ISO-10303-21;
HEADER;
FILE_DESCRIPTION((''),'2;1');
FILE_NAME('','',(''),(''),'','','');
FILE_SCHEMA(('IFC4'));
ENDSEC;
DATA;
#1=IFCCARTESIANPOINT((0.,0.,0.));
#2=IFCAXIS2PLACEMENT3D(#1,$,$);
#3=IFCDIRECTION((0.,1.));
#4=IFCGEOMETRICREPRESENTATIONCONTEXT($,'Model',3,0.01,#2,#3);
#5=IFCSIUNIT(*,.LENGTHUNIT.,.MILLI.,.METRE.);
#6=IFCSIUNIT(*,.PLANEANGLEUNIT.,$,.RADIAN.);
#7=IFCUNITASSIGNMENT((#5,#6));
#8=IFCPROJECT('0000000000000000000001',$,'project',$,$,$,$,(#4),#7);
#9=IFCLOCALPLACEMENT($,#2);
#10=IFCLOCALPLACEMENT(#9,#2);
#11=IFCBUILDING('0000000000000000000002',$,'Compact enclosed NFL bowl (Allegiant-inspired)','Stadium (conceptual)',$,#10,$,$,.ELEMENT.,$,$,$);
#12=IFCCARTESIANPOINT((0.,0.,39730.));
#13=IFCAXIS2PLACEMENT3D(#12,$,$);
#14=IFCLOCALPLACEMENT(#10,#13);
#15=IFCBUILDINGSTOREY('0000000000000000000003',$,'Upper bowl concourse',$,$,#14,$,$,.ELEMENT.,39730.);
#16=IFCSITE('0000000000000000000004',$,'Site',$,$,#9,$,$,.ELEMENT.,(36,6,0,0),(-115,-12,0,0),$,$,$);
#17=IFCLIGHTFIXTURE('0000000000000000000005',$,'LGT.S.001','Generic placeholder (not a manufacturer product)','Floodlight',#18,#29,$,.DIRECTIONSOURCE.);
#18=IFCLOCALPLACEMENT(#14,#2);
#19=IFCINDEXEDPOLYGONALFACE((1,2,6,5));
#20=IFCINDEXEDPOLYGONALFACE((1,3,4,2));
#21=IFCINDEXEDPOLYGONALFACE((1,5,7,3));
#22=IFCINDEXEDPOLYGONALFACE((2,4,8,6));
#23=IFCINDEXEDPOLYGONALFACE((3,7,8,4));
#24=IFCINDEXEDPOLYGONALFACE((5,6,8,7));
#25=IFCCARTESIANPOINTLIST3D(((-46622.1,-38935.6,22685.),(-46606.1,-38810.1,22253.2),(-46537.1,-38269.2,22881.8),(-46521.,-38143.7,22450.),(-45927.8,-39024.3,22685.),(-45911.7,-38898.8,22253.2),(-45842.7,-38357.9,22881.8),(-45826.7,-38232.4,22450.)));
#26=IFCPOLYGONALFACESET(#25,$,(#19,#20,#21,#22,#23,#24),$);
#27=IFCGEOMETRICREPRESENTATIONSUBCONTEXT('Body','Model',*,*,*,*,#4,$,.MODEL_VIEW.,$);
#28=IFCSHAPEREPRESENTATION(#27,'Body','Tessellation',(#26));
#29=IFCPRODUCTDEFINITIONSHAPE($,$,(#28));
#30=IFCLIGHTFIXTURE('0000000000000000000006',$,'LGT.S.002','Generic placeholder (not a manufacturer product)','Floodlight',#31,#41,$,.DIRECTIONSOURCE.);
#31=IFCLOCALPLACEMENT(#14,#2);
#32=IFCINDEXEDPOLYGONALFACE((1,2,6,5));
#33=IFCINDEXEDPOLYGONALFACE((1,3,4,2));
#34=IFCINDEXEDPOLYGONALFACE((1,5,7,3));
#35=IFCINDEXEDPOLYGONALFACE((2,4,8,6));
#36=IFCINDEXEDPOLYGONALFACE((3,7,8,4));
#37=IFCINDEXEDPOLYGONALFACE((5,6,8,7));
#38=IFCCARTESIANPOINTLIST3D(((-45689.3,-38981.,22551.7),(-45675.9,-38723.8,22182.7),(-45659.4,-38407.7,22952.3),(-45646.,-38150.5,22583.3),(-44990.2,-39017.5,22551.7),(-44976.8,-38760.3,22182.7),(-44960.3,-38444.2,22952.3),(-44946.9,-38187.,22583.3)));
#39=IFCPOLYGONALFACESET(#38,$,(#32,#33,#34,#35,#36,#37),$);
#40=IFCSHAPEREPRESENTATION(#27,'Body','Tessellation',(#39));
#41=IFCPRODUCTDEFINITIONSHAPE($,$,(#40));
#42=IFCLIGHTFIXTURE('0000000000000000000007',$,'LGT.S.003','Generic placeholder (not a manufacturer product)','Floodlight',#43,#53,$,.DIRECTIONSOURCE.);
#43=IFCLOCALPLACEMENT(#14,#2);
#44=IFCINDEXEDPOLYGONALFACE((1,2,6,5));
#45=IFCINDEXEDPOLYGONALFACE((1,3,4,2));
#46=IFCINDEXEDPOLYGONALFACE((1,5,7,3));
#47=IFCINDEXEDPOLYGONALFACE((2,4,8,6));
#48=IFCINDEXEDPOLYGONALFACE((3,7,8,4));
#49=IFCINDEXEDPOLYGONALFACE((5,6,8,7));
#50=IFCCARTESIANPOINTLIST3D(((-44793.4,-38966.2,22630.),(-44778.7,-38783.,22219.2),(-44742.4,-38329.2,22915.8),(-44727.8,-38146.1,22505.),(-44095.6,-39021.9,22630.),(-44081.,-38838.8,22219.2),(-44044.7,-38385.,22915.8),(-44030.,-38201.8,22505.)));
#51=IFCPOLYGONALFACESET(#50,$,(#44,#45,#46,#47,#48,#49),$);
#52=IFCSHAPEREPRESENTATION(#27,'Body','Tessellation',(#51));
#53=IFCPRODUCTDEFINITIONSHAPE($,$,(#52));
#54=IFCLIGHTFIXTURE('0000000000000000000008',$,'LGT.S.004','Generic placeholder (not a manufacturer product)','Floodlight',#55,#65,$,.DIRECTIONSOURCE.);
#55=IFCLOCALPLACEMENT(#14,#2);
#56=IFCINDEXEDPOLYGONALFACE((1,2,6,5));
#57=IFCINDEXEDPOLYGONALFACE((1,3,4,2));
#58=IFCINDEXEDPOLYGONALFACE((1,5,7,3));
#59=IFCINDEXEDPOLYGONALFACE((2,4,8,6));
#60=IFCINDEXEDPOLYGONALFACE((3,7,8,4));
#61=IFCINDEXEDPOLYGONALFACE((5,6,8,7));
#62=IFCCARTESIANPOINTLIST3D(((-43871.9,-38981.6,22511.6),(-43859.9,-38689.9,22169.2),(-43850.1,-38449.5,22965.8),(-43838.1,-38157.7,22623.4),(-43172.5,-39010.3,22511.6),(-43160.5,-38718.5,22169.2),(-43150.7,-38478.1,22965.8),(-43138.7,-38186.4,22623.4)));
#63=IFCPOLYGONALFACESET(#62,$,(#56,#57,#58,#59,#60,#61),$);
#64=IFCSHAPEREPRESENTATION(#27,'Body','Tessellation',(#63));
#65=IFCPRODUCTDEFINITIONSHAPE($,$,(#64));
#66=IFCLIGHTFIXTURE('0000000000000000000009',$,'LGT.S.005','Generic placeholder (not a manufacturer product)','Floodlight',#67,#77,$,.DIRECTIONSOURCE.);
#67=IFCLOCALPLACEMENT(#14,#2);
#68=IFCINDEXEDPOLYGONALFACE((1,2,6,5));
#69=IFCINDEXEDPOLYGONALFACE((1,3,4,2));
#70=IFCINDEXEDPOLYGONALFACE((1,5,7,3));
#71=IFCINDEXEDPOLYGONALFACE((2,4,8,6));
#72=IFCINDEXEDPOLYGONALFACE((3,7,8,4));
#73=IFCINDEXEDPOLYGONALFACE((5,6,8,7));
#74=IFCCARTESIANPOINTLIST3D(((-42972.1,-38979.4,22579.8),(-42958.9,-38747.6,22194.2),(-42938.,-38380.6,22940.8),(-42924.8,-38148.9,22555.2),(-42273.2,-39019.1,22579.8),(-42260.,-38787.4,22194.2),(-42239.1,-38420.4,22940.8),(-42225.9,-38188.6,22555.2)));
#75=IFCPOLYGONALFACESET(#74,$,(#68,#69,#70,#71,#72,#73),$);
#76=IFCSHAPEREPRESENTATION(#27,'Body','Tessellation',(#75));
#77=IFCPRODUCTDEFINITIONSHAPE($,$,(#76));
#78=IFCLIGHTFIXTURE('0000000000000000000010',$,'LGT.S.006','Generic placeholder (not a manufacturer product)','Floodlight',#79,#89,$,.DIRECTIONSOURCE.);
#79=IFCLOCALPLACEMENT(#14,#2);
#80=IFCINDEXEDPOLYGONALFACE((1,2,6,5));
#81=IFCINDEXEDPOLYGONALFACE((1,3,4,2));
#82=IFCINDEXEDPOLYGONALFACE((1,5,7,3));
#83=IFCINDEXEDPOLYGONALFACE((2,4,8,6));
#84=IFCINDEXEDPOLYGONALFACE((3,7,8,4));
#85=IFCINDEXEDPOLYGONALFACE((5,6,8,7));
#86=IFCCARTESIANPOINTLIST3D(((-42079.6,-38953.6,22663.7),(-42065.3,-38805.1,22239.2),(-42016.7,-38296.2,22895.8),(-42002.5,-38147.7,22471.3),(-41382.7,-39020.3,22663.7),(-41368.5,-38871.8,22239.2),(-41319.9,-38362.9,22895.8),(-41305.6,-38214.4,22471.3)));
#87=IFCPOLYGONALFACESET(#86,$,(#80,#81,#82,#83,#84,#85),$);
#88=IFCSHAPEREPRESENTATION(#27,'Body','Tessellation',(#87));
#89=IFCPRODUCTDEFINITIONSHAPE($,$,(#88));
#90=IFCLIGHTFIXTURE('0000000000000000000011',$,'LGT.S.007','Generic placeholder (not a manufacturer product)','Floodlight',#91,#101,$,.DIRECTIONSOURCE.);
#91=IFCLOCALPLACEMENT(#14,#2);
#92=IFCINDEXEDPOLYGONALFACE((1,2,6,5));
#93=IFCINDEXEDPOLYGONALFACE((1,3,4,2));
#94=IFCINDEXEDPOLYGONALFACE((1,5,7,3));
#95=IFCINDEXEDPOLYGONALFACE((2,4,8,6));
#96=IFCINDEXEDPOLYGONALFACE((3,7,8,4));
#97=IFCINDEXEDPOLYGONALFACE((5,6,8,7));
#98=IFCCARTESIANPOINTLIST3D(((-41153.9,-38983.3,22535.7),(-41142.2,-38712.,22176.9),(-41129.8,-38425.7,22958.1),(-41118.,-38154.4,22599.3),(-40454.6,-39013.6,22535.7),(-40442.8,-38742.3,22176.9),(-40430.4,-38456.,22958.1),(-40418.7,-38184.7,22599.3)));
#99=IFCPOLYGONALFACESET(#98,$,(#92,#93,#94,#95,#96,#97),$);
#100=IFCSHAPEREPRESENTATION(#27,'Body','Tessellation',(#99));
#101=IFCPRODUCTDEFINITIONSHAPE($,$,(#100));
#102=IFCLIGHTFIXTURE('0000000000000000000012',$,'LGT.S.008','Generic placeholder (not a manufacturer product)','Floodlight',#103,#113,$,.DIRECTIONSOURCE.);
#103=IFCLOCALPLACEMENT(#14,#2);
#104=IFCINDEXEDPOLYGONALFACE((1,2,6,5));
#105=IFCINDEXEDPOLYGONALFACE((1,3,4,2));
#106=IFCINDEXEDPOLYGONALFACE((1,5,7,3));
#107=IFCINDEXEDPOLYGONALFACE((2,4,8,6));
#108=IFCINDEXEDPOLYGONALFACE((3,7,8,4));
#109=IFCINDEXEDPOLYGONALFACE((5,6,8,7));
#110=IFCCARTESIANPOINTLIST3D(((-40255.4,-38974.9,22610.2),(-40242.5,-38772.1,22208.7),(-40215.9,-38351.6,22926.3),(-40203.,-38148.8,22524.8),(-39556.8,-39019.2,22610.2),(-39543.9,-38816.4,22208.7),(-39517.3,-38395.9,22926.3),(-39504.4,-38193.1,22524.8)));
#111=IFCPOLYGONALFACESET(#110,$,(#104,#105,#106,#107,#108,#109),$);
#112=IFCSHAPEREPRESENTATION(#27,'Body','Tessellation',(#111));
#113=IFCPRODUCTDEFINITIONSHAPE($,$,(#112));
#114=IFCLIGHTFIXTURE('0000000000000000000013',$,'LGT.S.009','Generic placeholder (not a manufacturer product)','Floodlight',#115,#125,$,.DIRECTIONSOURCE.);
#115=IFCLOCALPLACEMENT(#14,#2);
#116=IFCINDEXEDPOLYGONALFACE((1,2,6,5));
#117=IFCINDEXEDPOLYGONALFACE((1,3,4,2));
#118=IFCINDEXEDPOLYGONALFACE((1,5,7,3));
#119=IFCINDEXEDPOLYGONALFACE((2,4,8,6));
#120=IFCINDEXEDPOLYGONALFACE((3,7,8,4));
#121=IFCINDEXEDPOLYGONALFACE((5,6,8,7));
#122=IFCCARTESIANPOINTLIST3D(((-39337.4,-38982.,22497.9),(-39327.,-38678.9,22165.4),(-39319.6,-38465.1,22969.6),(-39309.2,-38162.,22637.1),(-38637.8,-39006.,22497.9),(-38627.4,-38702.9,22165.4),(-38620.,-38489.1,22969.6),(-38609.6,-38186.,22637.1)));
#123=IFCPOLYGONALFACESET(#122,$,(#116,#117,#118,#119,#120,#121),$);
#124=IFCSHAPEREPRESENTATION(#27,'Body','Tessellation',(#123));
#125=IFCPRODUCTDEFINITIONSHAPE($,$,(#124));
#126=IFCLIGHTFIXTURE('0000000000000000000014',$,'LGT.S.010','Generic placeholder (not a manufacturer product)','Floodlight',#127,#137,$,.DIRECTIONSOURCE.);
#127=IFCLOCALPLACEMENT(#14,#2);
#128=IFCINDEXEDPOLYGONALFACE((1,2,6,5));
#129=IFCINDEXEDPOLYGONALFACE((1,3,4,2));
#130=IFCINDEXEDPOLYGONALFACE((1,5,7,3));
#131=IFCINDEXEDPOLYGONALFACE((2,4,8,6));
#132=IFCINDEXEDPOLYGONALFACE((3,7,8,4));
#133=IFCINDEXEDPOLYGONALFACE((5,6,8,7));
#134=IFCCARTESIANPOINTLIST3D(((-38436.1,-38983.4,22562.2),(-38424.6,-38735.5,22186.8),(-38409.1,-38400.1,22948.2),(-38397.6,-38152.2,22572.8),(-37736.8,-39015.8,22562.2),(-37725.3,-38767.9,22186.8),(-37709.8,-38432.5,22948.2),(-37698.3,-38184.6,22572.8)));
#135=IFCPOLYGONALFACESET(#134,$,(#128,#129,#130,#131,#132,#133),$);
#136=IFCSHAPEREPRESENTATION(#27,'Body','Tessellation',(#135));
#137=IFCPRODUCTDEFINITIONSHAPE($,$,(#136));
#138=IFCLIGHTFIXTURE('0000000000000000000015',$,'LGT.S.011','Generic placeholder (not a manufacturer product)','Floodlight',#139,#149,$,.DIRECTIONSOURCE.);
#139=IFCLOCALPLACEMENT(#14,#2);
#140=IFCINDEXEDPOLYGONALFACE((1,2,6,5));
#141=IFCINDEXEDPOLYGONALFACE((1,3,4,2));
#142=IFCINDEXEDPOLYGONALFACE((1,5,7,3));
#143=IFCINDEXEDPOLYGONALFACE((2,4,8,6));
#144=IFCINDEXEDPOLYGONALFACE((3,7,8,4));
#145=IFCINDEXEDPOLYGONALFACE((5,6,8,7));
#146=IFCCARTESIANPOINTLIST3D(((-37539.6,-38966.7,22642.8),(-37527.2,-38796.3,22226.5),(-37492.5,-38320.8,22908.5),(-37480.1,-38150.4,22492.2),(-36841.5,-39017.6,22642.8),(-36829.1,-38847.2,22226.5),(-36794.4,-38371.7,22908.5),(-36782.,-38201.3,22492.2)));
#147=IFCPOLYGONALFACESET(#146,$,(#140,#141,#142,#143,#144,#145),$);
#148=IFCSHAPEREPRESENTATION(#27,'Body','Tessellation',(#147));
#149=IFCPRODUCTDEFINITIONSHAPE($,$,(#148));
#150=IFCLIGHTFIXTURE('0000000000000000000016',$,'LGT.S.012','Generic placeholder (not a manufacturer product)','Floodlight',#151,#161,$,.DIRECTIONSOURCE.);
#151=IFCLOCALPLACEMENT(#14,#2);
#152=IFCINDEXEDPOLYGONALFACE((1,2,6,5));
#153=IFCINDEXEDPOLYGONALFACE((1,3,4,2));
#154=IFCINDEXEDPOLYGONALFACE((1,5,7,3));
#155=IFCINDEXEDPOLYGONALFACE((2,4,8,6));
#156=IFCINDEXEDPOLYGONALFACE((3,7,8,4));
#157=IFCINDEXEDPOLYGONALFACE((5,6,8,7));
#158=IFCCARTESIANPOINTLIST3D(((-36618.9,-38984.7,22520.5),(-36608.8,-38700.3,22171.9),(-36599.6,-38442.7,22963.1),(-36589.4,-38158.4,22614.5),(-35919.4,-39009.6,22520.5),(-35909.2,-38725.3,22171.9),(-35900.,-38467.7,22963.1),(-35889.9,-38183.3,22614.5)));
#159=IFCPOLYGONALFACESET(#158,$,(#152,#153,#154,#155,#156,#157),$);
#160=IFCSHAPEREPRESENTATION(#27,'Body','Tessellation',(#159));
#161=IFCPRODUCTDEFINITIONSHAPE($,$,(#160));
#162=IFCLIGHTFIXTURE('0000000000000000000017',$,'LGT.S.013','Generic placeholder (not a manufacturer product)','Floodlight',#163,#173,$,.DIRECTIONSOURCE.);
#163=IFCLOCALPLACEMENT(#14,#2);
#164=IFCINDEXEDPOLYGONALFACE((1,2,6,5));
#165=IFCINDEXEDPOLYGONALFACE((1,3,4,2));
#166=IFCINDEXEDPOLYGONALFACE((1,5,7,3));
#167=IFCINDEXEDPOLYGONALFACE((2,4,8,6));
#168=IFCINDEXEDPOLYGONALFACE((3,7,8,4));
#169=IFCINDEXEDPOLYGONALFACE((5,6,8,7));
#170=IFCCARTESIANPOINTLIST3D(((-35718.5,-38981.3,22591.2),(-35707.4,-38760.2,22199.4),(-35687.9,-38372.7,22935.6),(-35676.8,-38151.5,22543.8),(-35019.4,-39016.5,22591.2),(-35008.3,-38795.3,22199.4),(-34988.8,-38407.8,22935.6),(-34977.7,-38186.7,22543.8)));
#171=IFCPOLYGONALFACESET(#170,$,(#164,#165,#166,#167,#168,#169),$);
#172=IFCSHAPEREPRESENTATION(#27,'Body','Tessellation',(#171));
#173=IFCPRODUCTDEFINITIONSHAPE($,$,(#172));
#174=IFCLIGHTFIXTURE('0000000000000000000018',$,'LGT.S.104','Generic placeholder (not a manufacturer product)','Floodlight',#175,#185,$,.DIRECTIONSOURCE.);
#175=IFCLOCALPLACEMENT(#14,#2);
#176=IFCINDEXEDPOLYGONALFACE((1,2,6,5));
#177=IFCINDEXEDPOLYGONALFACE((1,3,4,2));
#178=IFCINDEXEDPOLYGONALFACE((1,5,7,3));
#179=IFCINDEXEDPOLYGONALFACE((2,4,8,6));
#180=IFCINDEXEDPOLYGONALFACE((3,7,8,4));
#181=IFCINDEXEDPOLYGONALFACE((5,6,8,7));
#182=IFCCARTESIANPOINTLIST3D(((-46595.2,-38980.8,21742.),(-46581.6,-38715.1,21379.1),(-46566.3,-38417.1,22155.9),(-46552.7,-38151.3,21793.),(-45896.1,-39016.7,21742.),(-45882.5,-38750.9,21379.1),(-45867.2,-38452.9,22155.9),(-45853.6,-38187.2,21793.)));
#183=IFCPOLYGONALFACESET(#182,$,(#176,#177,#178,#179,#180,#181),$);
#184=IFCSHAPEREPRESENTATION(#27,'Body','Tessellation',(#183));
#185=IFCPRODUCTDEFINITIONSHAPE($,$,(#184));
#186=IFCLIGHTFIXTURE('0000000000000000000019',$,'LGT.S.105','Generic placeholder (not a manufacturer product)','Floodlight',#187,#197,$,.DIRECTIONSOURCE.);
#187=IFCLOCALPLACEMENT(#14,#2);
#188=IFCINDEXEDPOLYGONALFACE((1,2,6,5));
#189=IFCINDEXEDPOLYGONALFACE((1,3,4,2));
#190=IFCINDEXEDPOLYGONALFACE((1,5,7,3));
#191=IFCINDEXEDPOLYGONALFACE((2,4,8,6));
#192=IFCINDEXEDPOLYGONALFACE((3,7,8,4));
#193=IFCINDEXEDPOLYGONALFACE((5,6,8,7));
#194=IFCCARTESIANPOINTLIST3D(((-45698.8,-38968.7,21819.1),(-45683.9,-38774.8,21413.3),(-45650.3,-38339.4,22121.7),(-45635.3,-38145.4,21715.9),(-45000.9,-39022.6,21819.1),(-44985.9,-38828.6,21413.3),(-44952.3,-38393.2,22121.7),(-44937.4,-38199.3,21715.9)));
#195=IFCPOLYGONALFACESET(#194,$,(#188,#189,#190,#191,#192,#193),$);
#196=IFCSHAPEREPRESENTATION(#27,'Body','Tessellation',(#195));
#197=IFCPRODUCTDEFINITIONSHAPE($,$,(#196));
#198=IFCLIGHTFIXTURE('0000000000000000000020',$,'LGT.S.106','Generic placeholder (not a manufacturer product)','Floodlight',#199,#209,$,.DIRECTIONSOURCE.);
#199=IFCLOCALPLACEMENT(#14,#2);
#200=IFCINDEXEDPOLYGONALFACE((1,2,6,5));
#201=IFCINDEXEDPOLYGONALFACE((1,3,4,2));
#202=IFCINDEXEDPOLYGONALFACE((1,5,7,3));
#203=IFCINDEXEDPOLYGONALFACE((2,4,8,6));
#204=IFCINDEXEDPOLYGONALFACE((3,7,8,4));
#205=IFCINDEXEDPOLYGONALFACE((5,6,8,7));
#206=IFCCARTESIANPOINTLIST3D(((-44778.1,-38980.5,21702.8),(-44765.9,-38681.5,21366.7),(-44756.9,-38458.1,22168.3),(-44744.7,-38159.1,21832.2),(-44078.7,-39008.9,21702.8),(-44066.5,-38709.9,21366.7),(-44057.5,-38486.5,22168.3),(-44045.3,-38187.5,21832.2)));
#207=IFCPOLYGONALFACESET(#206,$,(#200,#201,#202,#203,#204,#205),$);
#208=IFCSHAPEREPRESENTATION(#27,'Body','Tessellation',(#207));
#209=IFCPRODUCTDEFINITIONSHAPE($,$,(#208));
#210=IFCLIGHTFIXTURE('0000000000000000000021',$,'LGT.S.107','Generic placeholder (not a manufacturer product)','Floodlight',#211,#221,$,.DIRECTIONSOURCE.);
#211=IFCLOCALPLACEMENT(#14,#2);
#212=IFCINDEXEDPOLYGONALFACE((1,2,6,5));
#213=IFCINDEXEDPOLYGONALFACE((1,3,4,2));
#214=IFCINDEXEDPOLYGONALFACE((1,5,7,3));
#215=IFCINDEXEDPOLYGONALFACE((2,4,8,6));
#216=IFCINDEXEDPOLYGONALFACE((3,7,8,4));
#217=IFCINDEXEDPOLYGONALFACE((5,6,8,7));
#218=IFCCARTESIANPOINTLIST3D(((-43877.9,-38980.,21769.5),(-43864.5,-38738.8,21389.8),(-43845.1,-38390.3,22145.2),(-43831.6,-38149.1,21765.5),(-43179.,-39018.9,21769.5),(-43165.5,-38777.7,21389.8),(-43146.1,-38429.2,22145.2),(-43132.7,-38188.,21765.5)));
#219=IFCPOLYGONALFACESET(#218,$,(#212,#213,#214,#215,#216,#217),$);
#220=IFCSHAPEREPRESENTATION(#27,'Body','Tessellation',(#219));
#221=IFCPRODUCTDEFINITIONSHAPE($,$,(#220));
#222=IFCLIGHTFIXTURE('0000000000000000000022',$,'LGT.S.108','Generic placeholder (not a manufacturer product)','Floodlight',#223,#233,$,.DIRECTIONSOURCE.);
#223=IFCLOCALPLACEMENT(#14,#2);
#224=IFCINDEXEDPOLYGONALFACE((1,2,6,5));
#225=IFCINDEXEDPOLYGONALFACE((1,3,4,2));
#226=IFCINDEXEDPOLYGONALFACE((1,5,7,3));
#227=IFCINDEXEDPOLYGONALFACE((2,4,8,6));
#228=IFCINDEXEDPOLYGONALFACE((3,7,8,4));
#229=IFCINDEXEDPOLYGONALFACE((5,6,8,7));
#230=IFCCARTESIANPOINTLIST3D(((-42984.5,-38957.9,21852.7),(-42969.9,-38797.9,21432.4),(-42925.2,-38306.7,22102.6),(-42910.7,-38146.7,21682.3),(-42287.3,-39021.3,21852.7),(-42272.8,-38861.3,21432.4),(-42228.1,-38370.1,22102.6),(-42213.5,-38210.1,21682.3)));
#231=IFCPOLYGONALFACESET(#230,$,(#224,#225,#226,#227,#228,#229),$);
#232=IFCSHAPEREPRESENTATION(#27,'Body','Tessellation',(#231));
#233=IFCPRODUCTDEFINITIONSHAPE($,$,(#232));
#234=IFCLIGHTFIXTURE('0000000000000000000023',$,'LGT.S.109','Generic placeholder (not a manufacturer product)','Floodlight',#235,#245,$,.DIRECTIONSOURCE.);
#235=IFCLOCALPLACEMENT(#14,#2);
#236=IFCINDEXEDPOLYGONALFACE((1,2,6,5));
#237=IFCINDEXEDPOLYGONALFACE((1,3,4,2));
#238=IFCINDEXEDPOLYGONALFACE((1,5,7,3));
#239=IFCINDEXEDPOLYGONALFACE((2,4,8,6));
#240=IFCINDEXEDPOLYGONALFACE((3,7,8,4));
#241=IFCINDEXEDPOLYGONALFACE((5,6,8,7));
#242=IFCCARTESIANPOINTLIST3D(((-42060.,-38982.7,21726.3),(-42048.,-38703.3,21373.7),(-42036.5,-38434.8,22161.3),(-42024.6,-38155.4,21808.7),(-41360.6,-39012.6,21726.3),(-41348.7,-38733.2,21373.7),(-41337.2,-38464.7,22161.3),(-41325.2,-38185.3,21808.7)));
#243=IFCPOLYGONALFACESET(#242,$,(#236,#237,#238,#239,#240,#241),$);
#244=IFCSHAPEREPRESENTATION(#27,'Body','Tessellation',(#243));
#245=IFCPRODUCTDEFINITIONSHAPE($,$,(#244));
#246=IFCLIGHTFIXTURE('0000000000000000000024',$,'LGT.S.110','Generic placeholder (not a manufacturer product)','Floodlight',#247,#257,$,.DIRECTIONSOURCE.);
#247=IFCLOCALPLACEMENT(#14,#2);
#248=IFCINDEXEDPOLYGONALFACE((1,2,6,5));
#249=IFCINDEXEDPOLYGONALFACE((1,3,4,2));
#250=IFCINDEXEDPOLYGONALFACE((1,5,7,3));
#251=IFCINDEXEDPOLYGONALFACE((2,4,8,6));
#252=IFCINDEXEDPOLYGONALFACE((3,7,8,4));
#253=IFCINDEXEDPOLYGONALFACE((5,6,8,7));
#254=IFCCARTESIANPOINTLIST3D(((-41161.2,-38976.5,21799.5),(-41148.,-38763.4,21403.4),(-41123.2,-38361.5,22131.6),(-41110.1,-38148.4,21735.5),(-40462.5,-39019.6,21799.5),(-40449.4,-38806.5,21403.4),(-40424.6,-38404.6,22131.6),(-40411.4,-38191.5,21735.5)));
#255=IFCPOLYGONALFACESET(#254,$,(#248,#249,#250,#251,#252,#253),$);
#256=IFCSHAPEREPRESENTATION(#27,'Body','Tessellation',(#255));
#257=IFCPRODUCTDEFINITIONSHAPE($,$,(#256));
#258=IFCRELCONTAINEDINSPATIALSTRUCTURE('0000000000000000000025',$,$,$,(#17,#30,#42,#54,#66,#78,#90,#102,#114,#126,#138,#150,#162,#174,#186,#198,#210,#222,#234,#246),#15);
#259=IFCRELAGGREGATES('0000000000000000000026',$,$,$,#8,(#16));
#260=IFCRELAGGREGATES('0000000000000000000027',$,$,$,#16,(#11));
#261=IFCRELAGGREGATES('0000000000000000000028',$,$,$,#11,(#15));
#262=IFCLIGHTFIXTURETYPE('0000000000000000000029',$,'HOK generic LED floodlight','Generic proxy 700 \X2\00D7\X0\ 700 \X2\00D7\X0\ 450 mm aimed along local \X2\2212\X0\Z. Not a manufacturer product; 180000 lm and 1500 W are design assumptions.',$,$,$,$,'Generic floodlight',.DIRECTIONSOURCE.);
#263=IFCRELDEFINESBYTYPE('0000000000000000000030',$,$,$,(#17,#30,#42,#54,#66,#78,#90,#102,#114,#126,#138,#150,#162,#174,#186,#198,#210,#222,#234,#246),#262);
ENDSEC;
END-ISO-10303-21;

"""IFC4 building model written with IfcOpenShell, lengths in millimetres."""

from ifc_helpers import new_model, si_unit, direction, frame, origin, place, context, subcontext, project, spatial, rectangle, extrude, source, transform, mapped, type_object, type_shapes, element, save


model = new_model("IFC4")

# Units and contexts
model_context = context("Model", 3, precision=0.01, world=origin(), true_north=direction((0.0, 1.0)))
body_context = subcontext(model_context, "Body", "Model", "MODEL_VIEW")
ifc_project = project(units=[si_unit("LENGTHUNIT", "METRE", prefix="MILLI"), si_unit("PLANEANGLEUNIT", "RADIAN")], contexts=[model_context])

# Site, building, storey
site_placement = place(None, origin())
site = spatial("IfcSite", under=ifc_project, at=site_placement, Name="Site", CompositionType="ELEMENT", RefLatitude=(36, 6, 0, 0), RefLongitude=(-115, -12, 0, 0))
building_placement = place(site_placement, origin())
building = spatial("IfcBuilding", under=site, at=building_placement, Name="Compact enclosed NFL bowl (Allegiant-inspired)", Description="Stadium (conceptual)", CompositionType="ELEMENT")
storey_placement = place(building_placement, frame((0.0, 0.0, 39730.0)))
storey = spatial("IfcBuildingStorey", under=building, at=storey_placement, Name="Upper bowl concourse", CompositionType="ELEMENT", Elevation=39730.0)

# Light fixtures
light_fixture_type = type_object("IfcLightFixtureType", Name="HOK generic LED floodlight", Description="Generic proxy 700 × 700 × 450 mm aimed along local −Z. Not a manufacturer product; 180000 lm and 1500 W are design assumptions.", ElementType="Generic floodlight", PredefinedType="DIRECTIONSOURCE")
shared_shape = source(origin(), body_context, "Body", "SweptSolid", [
    extrude(rectangle(XDim=700.0, YDim=700.0), frame((0.0, 0.0, -225.0)), (0.0, 0.0, 1.0), 450.0),
])
type_shapes(light_fixture_type, [shared_shape])
for number, where, z_axis, x_axis, name in (
    (1, (-46224.4, -38584.0, 22567.5), (-0.035604, -0.278848, 0.959675), (0.991947, -0.126653, 0.0), "LGT.S.001"),
    (2, (-45318.1, -38584.0, 22567.5), (-0.029827, -0.571537, 0.820034), (0.998641, -0.052116, 0.0), "LGT.S.002"),
    (3, (-44411.7, -38584.0, 22567.5), (-0.032539, -0.406954, 0.912869), (0.996819, -0.079703, 0.0), "LGT.S.003"),
    (4, (-43505.3, -38584.0, 22567.5), (-0.026567, -0.64839, 0.760844), (0.999162, -0.040939, 0.0), "LGT.S.004"),
    (5, (-42599.0, -38584.0, 22567.5), (-0.029292, -0.514923, 0.856736), (0.998386, -0.056794, 0.0), "LGT.S.005"),
    (6, (-41692.6, -38584.0, 22567.5), (-0.03157, -0.330066, 0.94343), (0.995457, -0.095212, 0.0), "LGT.S.006"),
    (7, (-40786.3, -38584.0, 22567.5), (-0.026101, -0.602985, 0.797325), (0.999064, -0.043245, 0.0), "LGT.S.007"),
    (8, (-39879.9, -38584.0, 22567.5), (-0.028558, -0.45066, 0.892239), (0.997998, -0.063243, 0.0), "LGT.S.008"),
    (9, (-38973.5, -38584.0, 22567.5), (-0.023112, -0.673464, 0.738859), (0.999412, -0.034297, 0.0), "LGT.S.009"),
    (10, (-38067.2, -38584.0, 22567.5), (-0.025488, -0.55085, 0.834215), (0.998931, -0.04622, 0.0), "LGT.S.010"),
    (11, (-37160.8, -38584.0, 22567.5), (-0.027594, -0.378536, 0.925175), (0.997354, -0.072703, 0.0), "LGT.S.011"),
    (12, (-36254.4, -38584.0, 22567.5), (-0.022544, -0.631856, 0.774758), (0.999364, -0.035656, 0.0), "LGT.S.012"),
    (13, (-35348.1, -38584.0, 22567.5), (-0.0247, -0.491356, 0.870608), (0.998739, -0.050205, 0.0), "LGT.S.013"),
    (14, (-46224.4, -38584.0, 21767.5), (-0.030307, -0.590562, 0.806423), (0.998686, -0.051252, 0.0), "LGT.S.104"),
    (15, (-45318.1, -38584.0, 21767.5), (-0.033226, -0.430942, 0.901768), (0.997041, -0.076873, 0.0), "LGT.S.105"),
    (16, (-44411.7, -38584.0, 21767.5), (-0.026969, -0.664408, 0.746883), (0.999177, -0.040557, 0.0), "LGT.S.106"),
    (17, (-43505.3, -38584.0, 21767.5), (-0.029845, -0.535899, 0.843754), (0.998453, -0.055605, 0.0), "LGT.S.107"),
    (18, (-42599.0, -38584.0, 21767.5), (-0.032352, -0.355602, 0.934077), (0.995887, -0.090603, 0.0), "LGT.S.108"),
    (19, (-41692.6, -38584.0, 21767.5), (-0.026559, -0.620831, 0.783494), (0.999086, -0.04274, 0.0), "LGT.S.109"),
    (20, (-40786.3, -38584.0, 21767.5), (-0.029191, -0.473549, 0.880284), (0.998105, -0.061526, 0.0), "LGT.S.110"),
):
    element("IfcLightFixture", number, at=place(storey_placement, frame(where, z_axis=z_axis, x_axis=x_axis)), inside=storey, type_object=light_fixture_type, Name=name, Description="Generic placeholder (not a manufacturer product)", ObjectType="Floodlight", PredefinedType="DIRECTIONSOURCE", context=body_context, shape_type="MappedRepresentation", body=[
        mapped(shared_shape, transform((0.0, 0.0, 0.0))),
    ])

save(model, "model.ifc")
